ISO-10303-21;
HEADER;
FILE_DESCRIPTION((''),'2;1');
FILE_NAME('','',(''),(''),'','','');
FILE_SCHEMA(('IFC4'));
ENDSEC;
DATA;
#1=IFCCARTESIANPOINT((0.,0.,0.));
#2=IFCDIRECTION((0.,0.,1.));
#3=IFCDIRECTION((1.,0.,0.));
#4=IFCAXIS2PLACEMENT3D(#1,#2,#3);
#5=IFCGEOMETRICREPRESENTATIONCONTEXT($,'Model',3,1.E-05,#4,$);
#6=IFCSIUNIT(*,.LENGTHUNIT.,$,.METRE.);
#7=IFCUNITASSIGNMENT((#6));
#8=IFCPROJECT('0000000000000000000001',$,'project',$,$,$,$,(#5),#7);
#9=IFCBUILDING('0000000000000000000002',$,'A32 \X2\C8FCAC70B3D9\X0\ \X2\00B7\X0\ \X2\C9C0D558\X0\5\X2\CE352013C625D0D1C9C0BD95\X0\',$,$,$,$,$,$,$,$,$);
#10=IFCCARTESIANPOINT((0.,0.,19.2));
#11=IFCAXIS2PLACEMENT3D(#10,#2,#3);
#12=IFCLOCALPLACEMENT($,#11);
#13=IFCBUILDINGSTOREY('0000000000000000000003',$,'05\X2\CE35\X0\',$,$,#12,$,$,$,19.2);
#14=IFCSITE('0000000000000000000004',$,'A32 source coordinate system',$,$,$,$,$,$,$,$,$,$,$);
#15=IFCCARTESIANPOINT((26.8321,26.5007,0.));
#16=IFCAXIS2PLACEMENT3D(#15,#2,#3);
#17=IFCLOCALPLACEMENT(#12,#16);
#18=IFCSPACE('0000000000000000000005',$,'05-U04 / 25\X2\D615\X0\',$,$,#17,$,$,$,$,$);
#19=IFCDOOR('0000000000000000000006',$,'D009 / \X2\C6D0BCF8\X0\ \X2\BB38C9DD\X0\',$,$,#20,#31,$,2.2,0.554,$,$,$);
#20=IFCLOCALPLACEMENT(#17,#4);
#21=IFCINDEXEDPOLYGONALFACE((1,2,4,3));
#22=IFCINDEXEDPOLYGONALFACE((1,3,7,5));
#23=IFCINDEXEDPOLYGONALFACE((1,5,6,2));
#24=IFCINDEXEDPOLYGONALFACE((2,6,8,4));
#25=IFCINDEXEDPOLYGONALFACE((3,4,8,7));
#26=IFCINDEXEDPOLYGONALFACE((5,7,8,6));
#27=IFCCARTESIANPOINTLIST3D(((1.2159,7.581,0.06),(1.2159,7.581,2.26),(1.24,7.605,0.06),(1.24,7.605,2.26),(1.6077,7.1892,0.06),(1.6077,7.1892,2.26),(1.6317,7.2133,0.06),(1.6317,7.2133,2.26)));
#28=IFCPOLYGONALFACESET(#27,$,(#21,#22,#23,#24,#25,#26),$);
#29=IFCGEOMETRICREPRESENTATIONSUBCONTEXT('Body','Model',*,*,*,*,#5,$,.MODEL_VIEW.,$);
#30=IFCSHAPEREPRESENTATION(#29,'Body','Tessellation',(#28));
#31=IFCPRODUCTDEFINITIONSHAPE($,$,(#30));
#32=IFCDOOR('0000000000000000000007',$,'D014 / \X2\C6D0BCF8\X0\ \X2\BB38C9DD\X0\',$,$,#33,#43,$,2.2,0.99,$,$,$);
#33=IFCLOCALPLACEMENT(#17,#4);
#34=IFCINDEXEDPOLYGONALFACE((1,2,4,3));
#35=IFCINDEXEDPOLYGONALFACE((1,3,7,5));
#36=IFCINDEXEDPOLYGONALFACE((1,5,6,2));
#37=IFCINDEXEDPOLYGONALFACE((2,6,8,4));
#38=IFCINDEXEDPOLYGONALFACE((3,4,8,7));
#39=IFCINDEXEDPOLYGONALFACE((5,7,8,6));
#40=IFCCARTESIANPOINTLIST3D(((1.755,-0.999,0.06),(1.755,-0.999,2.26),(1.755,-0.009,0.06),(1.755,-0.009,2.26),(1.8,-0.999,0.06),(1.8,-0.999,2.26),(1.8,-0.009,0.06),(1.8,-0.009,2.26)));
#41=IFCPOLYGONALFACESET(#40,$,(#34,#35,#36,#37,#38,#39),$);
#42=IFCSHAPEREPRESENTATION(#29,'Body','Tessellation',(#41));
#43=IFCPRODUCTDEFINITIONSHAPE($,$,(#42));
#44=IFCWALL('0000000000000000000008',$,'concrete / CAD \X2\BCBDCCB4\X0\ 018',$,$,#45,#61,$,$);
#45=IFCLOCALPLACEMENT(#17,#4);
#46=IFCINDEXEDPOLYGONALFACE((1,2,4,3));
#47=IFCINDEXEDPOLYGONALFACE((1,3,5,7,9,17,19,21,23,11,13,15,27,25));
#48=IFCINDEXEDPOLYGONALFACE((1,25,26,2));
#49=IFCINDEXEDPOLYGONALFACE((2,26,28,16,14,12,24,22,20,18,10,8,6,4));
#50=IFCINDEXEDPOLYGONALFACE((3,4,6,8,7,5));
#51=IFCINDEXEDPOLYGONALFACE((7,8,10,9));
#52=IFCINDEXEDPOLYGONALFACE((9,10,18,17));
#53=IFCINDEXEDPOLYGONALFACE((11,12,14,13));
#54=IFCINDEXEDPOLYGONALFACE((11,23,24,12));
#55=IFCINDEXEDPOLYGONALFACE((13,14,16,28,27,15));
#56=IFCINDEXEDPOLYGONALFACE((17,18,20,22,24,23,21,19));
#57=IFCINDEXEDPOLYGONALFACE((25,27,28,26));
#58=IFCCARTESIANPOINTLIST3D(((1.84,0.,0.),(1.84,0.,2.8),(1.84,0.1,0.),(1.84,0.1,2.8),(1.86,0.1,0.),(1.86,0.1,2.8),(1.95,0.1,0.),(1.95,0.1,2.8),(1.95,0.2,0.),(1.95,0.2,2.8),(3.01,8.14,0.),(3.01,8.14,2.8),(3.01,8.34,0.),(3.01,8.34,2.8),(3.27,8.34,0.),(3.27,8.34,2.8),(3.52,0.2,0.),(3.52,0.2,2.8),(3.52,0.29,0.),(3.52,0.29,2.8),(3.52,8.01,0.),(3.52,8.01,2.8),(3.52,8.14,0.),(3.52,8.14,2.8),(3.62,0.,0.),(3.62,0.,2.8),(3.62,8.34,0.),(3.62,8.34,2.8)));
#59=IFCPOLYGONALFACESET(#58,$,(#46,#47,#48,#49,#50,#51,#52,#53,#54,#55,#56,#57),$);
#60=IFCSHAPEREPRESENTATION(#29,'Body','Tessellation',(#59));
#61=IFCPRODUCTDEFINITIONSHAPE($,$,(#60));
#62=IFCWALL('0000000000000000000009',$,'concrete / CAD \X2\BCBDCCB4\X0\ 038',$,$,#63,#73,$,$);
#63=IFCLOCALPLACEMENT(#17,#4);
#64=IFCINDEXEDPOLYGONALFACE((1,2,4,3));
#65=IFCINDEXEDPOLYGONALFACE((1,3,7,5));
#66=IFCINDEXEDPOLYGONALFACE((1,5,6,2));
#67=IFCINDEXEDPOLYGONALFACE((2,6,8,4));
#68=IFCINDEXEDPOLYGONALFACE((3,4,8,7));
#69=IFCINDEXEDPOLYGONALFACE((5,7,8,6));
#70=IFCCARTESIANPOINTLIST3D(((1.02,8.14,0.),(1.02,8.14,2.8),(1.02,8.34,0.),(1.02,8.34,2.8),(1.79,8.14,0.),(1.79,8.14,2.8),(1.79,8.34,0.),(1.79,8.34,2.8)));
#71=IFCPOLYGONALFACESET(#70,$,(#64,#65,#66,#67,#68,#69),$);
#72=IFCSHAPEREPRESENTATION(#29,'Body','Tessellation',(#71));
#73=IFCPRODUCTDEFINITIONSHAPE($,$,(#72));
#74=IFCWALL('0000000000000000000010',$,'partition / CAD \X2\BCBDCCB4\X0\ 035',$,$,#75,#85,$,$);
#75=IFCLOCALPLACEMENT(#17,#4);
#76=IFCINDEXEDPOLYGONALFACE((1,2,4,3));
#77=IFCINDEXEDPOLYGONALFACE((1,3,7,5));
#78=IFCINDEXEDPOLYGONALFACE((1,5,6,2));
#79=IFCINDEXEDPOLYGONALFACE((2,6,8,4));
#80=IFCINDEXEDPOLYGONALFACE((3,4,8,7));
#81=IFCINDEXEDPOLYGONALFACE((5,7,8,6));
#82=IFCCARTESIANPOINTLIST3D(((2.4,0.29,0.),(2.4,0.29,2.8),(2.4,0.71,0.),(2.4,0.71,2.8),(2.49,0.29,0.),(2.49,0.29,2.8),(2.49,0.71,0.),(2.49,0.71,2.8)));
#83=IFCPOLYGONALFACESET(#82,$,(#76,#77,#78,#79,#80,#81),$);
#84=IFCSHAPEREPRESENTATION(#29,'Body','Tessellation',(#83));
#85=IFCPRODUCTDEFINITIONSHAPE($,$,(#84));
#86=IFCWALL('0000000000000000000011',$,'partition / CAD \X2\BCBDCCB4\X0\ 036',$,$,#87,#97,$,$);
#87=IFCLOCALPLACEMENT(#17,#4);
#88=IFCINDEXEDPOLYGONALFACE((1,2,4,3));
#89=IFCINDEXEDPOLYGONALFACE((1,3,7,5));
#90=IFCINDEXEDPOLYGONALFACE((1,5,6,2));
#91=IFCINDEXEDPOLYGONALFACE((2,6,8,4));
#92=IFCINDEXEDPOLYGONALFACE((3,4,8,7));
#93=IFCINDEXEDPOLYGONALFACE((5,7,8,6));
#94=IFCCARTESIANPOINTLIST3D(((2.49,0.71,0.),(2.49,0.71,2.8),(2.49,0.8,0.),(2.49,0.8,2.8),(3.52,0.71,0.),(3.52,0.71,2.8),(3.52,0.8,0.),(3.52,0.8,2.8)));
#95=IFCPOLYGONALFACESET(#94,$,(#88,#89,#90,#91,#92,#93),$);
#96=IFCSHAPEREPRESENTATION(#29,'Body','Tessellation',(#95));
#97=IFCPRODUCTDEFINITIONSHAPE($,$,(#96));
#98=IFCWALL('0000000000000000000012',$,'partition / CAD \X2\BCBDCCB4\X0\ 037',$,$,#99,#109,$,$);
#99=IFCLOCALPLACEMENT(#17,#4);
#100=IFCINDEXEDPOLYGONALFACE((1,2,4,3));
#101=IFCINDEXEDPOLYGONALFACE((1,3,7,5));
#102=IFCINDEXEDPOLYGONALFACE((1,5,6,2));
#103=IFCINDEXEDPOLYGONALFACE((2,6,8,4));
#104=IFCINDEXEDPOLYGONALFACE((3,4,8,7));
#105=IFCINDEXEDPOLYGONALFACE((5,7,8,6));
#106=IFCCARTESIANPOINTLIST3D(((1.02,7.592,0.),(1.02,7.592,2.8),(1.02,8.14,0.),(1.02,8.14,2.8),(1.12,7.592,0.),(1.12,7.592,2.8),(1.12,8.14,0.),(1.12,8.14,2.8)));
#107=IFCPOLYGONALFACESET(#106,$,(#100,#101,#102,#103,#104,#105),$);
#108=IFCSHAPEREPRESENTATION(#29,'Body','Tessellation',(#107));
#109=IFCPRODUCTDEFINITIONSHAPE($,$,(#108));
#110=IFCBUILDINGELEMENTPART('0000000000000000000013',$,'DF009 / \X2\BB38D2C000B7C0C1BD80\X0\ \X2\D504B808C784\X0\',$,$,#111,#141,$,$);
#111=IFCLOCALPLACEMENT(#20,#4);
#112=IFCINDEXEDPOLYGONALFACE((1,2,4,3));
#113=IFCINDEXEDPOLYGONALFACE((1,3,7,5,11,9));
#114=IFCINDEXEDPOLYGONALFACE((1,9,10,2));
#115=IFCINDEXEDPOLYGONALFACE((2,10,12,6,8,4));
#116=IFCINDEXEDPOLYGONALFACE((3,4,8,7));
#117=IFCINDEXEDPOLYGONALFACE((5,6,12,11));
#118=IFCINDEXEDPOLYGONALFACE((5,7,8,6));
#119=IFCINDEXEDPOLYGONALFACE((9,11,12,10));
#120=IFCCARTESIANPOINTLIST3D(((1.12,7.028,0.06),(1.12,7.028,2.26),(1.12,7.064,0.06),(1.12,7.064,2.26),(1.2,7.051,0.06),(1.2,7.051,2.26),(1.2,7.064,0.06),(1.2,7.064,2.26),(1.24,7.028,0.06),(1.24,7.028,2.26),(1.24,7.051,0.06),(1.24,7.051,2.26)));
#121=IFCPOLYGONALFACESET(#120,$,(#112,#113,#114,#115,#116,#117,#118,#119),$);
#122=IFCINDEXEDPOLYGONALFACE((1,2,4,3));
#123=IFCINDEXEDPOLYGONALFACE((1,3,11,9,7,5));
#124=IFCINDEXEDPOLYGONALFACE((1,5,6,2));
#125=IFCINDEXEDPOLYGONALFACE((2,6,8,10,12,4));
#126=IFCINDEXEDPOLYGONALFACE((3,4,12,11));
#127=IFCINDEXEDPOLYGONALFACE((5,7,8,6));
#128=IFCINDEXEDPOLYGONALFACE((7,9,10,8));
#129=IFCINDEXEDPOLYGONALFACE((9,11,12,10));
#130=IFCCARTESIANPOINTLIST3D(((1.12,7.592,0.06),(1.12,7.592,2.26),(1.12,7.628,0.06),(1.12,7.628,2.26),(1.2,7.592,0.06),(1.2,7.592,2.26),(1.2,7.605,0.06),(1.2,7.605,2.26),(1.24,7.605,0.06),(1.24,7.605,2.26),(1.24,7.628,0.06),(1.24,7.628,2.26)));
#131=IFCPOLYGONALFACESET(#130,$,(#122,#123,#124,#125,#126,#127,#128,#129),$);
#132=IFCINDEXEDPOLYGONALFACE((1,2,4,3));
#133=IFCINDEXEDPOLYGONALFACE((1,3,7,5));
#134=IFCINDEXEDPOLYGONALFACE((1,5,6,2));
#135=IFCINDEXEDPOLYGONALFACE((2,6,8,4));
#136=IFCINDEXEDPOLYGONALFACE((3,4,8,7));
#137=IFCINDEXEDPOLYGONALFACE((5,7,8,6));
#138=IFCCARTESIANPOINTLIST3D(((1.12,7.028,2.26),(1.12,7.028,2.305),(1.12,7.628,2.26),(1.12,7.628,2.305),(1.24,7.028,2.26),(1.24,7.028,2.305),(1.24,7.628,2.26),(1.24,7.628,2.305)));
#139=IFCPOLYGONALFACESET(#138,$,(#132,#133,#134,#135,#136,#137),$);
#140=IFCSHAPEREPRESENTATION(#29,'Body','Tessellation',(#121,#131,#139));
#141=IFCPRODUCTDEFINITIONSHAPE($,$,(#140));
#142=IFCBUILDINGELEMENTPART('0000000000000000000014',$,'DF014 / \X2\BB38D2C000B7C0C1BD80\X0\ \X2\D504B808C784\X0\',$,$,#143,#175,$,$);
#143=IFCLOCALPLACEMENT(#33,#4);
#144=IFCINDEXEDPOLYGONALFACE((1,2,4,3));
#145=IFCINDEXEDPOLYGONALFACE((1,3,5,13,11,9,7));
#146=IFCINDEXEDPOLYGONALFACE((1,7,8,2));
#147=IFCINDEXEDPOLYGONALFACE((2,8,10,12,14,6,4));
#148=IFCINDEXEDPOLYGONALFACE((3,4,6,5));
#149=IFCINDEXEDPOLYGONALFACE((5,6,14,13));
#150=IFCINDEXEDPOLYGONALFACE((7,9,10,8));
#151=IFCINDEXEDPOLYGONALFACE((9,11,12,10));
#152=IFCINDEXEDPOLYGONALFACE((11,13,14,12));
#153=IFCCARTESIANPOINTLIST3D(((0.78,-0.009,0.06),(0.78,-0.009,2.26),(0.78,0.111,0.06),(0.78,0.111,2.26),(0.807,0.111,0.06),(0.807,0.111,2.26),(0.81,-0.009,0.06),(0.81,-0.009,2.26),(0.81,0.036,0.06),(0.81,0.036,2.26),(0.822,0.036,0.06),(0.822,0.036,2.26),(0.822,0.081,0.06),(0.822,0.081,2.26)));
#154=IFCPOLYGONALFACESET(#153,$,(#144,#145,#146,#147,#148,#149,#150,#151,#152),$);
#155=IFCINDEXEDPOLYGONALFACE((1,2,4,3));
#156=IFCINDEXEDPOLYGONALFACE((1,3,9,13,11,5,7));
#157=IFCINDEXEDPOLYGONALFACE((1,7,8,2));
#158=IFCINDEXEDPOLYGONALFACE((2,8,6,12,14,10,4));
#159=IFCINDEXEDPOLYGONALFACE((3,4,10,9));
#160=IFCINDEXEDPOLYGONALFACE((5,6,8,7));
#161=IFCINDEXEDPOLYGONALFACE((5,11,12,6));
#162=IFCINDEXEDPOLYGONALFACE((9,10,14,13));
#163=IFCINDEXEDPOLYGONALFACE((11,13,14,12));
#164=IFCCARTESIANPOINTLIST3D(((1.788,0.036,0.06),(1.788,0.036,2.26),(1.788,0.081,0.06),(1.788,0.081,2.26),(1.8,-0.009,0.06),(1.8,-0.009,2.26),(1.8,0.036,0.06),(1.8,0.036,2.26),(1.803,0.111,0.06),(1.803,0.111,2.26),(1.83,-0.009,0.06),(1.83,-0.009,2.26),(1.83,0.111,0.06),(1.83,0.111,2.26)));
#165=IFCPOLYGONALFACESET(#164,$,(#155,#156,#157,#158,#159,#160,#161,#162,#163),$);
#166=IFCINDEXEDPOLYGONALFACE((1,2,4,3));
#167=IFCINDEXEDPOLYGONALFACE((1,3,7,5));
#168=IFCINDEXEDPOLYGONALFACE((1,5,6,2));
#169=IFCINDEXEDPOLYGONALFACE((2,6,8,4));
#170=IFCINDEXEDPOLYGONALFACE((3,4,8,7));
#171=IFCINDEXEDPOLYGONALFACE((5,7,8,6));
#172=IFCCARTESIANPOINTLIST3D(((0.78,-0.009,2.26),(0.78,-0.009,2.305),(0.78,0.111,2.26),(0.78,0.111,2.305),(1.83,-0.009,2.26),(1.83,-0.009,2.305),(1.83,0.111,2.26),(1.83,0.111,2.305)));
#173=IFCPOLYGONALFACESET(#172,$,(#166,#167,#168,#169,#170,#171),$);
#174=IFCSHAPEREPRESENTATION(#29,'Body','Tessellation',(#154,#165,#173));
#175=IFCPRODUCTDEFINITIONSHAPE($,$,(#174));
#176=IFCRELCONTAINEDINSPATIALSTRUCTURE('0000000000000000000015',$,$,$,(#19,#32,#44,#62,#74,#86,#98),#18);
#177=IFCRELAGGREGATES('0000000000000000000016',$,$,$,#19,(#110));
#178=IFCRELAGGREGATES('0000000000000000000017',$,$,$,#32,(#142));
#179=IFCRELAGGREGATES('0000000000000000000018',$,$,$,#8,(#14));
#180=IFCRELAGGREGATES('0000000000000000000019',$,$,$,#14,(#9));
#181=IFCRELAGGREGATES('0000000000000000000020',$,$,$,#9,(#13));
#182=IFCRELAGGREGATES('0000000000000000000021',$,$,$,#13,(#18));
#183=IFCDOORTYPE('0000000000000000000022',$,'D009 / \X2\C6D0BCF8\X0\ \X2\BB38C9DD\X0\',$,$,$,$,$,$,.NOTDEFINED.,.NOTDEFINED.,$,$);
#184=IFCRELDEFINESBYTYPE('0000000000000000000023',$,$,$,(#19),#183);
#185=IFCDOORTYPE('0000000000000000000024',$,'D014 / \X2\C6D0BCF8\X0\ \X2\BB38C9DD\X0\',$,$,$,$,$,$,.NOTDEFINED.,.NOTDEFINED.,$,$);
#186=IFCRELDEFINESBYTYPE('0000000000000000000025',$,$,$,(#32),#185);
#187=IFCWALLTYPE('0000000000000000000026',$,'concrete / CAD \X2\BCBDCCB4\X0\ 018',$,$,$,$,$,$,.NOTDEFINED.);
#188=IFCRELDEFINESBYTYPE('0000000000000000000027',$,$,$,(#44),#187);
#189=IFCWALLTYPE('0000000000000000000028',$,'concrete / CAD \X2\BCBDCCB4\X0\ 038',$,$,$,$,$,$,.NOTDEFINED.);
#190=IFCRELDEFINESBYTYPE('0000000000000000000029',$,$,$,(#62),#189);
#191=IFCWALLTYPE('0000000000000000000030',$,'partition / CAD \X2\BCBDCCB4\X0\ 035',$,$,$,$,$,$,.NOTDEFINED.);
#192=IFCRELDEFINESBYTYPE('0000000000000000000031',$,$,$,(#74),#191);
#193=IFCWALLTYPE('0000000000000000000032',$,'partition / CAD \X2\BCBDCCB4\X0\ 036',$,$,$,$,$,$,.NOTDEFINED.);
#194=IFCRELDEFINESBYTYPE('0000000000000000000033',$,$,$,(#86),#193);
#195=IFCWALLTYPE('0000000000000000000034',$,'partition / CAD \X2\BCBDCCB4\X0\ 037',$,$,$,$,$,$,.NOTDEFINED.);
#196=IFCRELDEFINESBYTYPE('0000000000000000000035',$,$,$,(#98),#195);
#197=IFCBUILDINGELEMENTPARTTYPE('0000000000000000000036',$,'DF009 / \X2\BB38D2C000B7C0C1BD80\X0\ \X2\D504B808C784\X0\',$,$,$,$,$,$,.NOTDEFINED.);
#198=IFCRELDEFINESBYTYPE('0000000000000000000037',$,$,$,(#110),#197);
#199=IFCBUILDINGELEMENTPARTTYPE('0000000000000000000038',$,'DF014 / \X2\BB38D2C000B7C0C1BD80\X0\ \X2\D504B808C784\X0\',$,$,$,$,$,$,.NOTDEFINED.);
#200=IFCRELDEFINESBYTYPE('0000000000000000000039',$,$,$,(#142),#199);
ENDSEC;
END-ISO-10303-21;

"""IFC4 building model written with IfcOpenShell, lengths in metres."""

from ifc_helpers import new_model, si_unit, frame, origin, origin_with_axes, place, context, subcontext, project, spatial, polyline, outline, extrude, source, transform, mapped, type_object, type_shapes, element, aggregate, save


model = new_model("IFC4")

# Units and contexts
model_context = context("Model", 3, precision=1e-05, world=origin_with_axes())
body_context = subcontext(model_context, "Body", "Model", "MODEL_VIEW")
ifc_project = project(units=[si_unit("LENGTHUNIT", "METRE")], contexts=[model_context])

# Site, building, storey, space
storey_placement = place(None, frame((0.0, 0.0, 19.2), z_axis=(0.0, 0.0, 1.0), x_axis=(1.0, 0.0, 0.0)))
space_placement = place(storey_placement, frame((26.8321, 26.5007, 0.0), z_axis=(0.0, 0.0, 1.0), x_axis=(1.0, 0.0, 0.0)))
site = spatial("IfcSite", under=ifc_project, Name="A32 source coordinate system")
building = spatial("IfcBuilding", under=site, Name="A32 주거동 · 지하5층–옥탑지붕")
storey = spatial("IfcBuildingStorey", under=building, at=storey_placement, Name="05층", Elevation=19.2)
space = spatial("IfcSpace", under=storey, at=space_placement, Name="05-U04 / 25형")

# Doors
door_type_1 = type_object("IfcDoorType", Name="D009 / 원본 문짝", OperationType="NOTDEFINED", PredefinedType="NOTDEFINED")
shared_shape_1 = source(origin(), body_context, "Body", "SweptSolid", [
    extrude(outline(polyline([(1.24, 7.605), (1.6317, 7.2133), (1.6077, 7.1892), (1.2159, 7.581), (1.24, 7.605)])), frame((0.0, 0.0, 0.06)), (0.0, 0.0, 1.0), 2.2),
])
type_shapes(door_type_1, [shared_shape_1])
door_1_placement = place(space_placement, origin_with_axes())
door_1 = element("IfcDoor", 1, at=door_1_placement, inside=space, type_object=door_type_1, Name="D009 / 원본 문짝", OverallHeight=2.2, OverallWidth=0.554, context=body_context, shape_type="MappedRepresentation", body=[
    mapped(shared_shape_1, transform((0.0, 0.0, 0.0), scale=1.0)),
])
door_type_2 = type_object("IfcDoorType", Name="D014 / 원본 문짝", OperationType="NOTDEFINED", PredefinedType="NOTDEFINED")
shared_shape_2 = source(origin(), body_context, "Body", "SweptSolid", [
    extrude(outline(polyline([(1.8, -0.009), (1.8, -0.999), (1.755, -0.999), (1.755, -0.009), (1.8, -0.009)])), frame((0.0, 0.0, 0.06)), (0.0, 0.0, 1.0), 2.2),
])
type_shapes(door_type_2, [shared_shape_2])
door_2_placement = place(space_placement, origin_with_axes())
door_2 = element("IfcDoor", 2, at=door_2_placement, inside=space, type_object=door_type_2, Name="D014 / 원본 문짝", OverallHeight=2.2, OverallWidth=0.99, context=body_context, shape_type="MappedRepresentation", body=[
    mapped(shared_shape_2, transform((0.0, 0.0, 0.0), scale=1.0)),
])

# Walls
wall_type_1 = type_object("IfcWallType", Name="concrete / CAD 벽체 018", PredefinedType="NOTDEFINED")
shared_shape_3 = source(origin(), body_context, "Body", "SweptSolid", [
    extrude(outline(polyline([(3.27, 8.34), (3.27, 8.34), (3.62, 8.34), (3.62, 0.0), (1.84, 0.0), (1.84, 0.1), (1.86, 0.1), (1.95, 0.1), (1.95, 0.2), (3.52, 0.2), (3.52, 0.29), (3.52, 8.01), (3.52, 8.14), (3.01, 8.14), (3.01, 8.34), (3.27, 8.34)])), origin(), (0.0, 0.0, 1.0), 2.8),
])
type_shapes(wall_type_1, [shared_shape_3])
wall_1_placement = place(space_placement, origin_with_axes())
element("IfcWall", 3, at=wall_1_placement, inside=space, type_object=wall_type_1, Name="concrete / CAD 벽체 018", context=body_context, shape_type="MappedRepresentation", body=[
    mapped(shared_shape_3, transform((0.0, 0.0, 0.0), scale=1.0)),
])
wall_type_2 = type_object("IfcWallType", Name="concrete / CAD 벽체 038", PredefinedType="NOTDEFINED")
shared_shape_4 = source(origin(), body_context, "Body", "SweptSolid", [
    extrude(outline(polyline([(1.02, 8.14), (1.02, 8.34), (1.79, 8.34), (1.79, 8.14), (1.02, 8.14)])), origin(), (0.0, 0.0, 1.0), 2.8),
])
type_shapes(wall_type_2, [shared_shape_4])
wall_2_placement = place(space_placement, origin_with_axes())
element("IfcWall", 4, at=wall_2_placement, inside=space, type_object=wall_type_2, Name="concrete / CAD 벽체 038", context=body_context, shape_type="MappedRepresentation", body=[
    mapped(shared_shape_4, transform((0.0, 0.0, 0.0), scale=1.0)),
])
wall_type_3 = type_object("IfcWallType", Name="partition / CAD 벽체 035", PredefinedType="NOTDEFINED")
shared_shape_5 = source(origin(), body_context, "Body", "SweptSolid", [
    extrude(outline(polyline([(2.49, 0.71), (2.49, 0.29), (2.4, 0.29), (2.4, 0.71), (2.49, 0.71)])), origin(), (0.0, 0.0, 1.0), 2.8),
])
type_shapes(wall_type_3, [shared_shape_5])
wall_3_placement = place(space_placement, origin_with_axes())
element("IfcWall", 5, at=wall_3_placement, inside=space, type_object=wall_type_3, Name="partition / CAD 벽체 035", context=body_context, shape_type="MappedRepresentation", body=[
    mapped(shared_shape_5, transform((0.0, 0.0, 0.0), scale=1.0)),
])
wall_type_4 = type_object("IfcWallType", Name="partition / CAD 벽체 036", PredefinedType="NOTDEFINED")
shared_shape_6 = source(origin(), body_context, "Body", "SweptSolid", [
    extrude(outline(polyline([(2.49, 0.8), (3.52, 0.8), (3.52, 0.71), (2.49, 0.71), (2.49, 0.8)])), origin(), (0.0, 0.0, 1.0), 2.8),
])
type_shapes(wall_type_4, [shared_shape_6])
wall_4_placement = place(space_placement, origin_with_axes())
element("IfcWall", 6, at=wall_4_placement, inside=space, type_object=wall_type_4, Name="partition / CAD 벽체 036", context=body_context, shape_type="MappedRepresentation", body=[
    mapped(shared_shape_6, transform((0.0, 0.0, 0.0), scale=1.0)),
])
wall_type_5 = type_object("IfcWallType", Name="partition / CAD 벽체 037", PredefinedType="NOTDEFINED")
shared_shape_7 = source(origin(), body_context, "Body", "SweptSolid", [
    extrude(outline(polyline([(1.02, 7.592), (1.02, 8.14), (1.12, 8.14), (1.12, 7.592), (1.02, 7.592)])), origin(), (0.0, 0.0, 1.0), 2.8),
])
type_shapes(wall_type_5, [shared_shape_7])
wall_5_placement = place(space_placement, origin_with_axes())
element("IfcWall", 7, at=wall_5_placement, inside=space, type_object=wall_type_5, Name="partition / CAD 벽체 037", context=body_context, shape_type="MappedRepresentation", body=[
    mapped(shared_shape_7, transform((0.0, 0.0, 0.0), scale=1.0)),
])

# Building element parts
building_element_part_type_1 = type_object("IfcBuildingElementPartType", Name="DF009 / 문틀·상부 프레임", PredefinedType="NOTDEFINED")
shared_shape_8 = source(origin(), body_context, "Body", "SweptSolid", [
    extrude(outline(polyline([(1.12, 7.064), (1.2, 7.064), (1.2, 7.051), (1.24, 7.051), (1.24, 7.028), (1.12, 7.028), (1.12, 7.064)])), frame((0.0, 0.0, 0.06)), (0.0, 0.0, 1.0), 2.2),
    extrude(outline(polyline([(1.24, 7.628), (1.24, 7.605), (1.2, 7.605), (1.2, 7.592), (1.12, 7.592), (1.12, 7.628), (1.24, 7.628)])), frame((0.0, 0.0, 0.06)), (0.0, 0.0, 1.0), 2.2),
    extrude(outline(polyline([(1.12, 7.028), (1.12, 7.628), (1.24, 7.628), (1.24, 7.028), (1.12, 7.028)])), frame((0.0, 0.0, 2.26)), (0.0, 0.0, 1.0), 0.045),
])
type_shapes(building_element_part_type_1, [shared_shape_8])
building_element_part_1_placement = place(door_1_placement, origin_with_axes())
building_element_part_1 = element("IfcBuildingElementPart", 8, at=building_element_part_1_placement, type_object=building_element_part_type_1, Name="DF009 / 문틀·상부 프레임", context=body_context, shape_type="MappedRepresentation", body=[
    mapped(shared_shape_8, transform((0.0, 0.0, 0.0), scale=1.0)),
])
aggregate(door_1, [building_element_part_1])
building_element_part_type_2 = type_object("IfcBuildingElementPartType", Name="DF014 / 문틀·상부 프레임", PredefinedType="NOTDEFINED")
shared_shape_9 = source(origin(), body_context, "Body", "SweptSolid", [
    extrude(outline(polyline([(0.78, 0.111), (0.807, 0.111), (0.822, 0.081), (0.822, 0.036), (0.81, 0.036), (0.81, -0.009), (0.78, -0.009), (0.78, 0.111)])), frame((0.0, 0.0, 0.06)), (0.0, 0.0, 1.0), 2.2),
    extrude(outline(polyline([(1.8, -0.009), (1.8, 0.036), (1.788, 0.036), (1.788, 0.081), (1.803, 0.111), (1.83, 0.111), (1.83, -0.009), (1.8, -0.009)])), frame((0.0, 0.0, 0.06)), (0.0, 0.0, 1.0), 2.2),
    extrude(outline(polyline([(0.78, -0.009), (0.78, 0.111), (1.83, 0.111), (1.83, -0.009), (0.78, -0.009)])), frame((0.0, 0.0, 2.26)), (0.0, 0.0, 1.0), 0.045),
])
type_shapes(building_element_part_type_2, [shared_shape_9])
building_element_part_2_placement = place(door_2_placement, origin_with_axes())
building_element_part_2 = element("IfcBuildingElementPart", 9, at=building_element_part_2_placement, type_object=building_element_part_type_2, Name="DF014 / 문틀·상부 프레임", context=body_context, shape_type="MappedRepresentation", body=[
    mapped(shared_shape_9, transform((0.0, 0.0, 0.0), scale=1.0)),
])
aggregate(door_2, [building_element_part_2])

save(model, "model.ifc")
